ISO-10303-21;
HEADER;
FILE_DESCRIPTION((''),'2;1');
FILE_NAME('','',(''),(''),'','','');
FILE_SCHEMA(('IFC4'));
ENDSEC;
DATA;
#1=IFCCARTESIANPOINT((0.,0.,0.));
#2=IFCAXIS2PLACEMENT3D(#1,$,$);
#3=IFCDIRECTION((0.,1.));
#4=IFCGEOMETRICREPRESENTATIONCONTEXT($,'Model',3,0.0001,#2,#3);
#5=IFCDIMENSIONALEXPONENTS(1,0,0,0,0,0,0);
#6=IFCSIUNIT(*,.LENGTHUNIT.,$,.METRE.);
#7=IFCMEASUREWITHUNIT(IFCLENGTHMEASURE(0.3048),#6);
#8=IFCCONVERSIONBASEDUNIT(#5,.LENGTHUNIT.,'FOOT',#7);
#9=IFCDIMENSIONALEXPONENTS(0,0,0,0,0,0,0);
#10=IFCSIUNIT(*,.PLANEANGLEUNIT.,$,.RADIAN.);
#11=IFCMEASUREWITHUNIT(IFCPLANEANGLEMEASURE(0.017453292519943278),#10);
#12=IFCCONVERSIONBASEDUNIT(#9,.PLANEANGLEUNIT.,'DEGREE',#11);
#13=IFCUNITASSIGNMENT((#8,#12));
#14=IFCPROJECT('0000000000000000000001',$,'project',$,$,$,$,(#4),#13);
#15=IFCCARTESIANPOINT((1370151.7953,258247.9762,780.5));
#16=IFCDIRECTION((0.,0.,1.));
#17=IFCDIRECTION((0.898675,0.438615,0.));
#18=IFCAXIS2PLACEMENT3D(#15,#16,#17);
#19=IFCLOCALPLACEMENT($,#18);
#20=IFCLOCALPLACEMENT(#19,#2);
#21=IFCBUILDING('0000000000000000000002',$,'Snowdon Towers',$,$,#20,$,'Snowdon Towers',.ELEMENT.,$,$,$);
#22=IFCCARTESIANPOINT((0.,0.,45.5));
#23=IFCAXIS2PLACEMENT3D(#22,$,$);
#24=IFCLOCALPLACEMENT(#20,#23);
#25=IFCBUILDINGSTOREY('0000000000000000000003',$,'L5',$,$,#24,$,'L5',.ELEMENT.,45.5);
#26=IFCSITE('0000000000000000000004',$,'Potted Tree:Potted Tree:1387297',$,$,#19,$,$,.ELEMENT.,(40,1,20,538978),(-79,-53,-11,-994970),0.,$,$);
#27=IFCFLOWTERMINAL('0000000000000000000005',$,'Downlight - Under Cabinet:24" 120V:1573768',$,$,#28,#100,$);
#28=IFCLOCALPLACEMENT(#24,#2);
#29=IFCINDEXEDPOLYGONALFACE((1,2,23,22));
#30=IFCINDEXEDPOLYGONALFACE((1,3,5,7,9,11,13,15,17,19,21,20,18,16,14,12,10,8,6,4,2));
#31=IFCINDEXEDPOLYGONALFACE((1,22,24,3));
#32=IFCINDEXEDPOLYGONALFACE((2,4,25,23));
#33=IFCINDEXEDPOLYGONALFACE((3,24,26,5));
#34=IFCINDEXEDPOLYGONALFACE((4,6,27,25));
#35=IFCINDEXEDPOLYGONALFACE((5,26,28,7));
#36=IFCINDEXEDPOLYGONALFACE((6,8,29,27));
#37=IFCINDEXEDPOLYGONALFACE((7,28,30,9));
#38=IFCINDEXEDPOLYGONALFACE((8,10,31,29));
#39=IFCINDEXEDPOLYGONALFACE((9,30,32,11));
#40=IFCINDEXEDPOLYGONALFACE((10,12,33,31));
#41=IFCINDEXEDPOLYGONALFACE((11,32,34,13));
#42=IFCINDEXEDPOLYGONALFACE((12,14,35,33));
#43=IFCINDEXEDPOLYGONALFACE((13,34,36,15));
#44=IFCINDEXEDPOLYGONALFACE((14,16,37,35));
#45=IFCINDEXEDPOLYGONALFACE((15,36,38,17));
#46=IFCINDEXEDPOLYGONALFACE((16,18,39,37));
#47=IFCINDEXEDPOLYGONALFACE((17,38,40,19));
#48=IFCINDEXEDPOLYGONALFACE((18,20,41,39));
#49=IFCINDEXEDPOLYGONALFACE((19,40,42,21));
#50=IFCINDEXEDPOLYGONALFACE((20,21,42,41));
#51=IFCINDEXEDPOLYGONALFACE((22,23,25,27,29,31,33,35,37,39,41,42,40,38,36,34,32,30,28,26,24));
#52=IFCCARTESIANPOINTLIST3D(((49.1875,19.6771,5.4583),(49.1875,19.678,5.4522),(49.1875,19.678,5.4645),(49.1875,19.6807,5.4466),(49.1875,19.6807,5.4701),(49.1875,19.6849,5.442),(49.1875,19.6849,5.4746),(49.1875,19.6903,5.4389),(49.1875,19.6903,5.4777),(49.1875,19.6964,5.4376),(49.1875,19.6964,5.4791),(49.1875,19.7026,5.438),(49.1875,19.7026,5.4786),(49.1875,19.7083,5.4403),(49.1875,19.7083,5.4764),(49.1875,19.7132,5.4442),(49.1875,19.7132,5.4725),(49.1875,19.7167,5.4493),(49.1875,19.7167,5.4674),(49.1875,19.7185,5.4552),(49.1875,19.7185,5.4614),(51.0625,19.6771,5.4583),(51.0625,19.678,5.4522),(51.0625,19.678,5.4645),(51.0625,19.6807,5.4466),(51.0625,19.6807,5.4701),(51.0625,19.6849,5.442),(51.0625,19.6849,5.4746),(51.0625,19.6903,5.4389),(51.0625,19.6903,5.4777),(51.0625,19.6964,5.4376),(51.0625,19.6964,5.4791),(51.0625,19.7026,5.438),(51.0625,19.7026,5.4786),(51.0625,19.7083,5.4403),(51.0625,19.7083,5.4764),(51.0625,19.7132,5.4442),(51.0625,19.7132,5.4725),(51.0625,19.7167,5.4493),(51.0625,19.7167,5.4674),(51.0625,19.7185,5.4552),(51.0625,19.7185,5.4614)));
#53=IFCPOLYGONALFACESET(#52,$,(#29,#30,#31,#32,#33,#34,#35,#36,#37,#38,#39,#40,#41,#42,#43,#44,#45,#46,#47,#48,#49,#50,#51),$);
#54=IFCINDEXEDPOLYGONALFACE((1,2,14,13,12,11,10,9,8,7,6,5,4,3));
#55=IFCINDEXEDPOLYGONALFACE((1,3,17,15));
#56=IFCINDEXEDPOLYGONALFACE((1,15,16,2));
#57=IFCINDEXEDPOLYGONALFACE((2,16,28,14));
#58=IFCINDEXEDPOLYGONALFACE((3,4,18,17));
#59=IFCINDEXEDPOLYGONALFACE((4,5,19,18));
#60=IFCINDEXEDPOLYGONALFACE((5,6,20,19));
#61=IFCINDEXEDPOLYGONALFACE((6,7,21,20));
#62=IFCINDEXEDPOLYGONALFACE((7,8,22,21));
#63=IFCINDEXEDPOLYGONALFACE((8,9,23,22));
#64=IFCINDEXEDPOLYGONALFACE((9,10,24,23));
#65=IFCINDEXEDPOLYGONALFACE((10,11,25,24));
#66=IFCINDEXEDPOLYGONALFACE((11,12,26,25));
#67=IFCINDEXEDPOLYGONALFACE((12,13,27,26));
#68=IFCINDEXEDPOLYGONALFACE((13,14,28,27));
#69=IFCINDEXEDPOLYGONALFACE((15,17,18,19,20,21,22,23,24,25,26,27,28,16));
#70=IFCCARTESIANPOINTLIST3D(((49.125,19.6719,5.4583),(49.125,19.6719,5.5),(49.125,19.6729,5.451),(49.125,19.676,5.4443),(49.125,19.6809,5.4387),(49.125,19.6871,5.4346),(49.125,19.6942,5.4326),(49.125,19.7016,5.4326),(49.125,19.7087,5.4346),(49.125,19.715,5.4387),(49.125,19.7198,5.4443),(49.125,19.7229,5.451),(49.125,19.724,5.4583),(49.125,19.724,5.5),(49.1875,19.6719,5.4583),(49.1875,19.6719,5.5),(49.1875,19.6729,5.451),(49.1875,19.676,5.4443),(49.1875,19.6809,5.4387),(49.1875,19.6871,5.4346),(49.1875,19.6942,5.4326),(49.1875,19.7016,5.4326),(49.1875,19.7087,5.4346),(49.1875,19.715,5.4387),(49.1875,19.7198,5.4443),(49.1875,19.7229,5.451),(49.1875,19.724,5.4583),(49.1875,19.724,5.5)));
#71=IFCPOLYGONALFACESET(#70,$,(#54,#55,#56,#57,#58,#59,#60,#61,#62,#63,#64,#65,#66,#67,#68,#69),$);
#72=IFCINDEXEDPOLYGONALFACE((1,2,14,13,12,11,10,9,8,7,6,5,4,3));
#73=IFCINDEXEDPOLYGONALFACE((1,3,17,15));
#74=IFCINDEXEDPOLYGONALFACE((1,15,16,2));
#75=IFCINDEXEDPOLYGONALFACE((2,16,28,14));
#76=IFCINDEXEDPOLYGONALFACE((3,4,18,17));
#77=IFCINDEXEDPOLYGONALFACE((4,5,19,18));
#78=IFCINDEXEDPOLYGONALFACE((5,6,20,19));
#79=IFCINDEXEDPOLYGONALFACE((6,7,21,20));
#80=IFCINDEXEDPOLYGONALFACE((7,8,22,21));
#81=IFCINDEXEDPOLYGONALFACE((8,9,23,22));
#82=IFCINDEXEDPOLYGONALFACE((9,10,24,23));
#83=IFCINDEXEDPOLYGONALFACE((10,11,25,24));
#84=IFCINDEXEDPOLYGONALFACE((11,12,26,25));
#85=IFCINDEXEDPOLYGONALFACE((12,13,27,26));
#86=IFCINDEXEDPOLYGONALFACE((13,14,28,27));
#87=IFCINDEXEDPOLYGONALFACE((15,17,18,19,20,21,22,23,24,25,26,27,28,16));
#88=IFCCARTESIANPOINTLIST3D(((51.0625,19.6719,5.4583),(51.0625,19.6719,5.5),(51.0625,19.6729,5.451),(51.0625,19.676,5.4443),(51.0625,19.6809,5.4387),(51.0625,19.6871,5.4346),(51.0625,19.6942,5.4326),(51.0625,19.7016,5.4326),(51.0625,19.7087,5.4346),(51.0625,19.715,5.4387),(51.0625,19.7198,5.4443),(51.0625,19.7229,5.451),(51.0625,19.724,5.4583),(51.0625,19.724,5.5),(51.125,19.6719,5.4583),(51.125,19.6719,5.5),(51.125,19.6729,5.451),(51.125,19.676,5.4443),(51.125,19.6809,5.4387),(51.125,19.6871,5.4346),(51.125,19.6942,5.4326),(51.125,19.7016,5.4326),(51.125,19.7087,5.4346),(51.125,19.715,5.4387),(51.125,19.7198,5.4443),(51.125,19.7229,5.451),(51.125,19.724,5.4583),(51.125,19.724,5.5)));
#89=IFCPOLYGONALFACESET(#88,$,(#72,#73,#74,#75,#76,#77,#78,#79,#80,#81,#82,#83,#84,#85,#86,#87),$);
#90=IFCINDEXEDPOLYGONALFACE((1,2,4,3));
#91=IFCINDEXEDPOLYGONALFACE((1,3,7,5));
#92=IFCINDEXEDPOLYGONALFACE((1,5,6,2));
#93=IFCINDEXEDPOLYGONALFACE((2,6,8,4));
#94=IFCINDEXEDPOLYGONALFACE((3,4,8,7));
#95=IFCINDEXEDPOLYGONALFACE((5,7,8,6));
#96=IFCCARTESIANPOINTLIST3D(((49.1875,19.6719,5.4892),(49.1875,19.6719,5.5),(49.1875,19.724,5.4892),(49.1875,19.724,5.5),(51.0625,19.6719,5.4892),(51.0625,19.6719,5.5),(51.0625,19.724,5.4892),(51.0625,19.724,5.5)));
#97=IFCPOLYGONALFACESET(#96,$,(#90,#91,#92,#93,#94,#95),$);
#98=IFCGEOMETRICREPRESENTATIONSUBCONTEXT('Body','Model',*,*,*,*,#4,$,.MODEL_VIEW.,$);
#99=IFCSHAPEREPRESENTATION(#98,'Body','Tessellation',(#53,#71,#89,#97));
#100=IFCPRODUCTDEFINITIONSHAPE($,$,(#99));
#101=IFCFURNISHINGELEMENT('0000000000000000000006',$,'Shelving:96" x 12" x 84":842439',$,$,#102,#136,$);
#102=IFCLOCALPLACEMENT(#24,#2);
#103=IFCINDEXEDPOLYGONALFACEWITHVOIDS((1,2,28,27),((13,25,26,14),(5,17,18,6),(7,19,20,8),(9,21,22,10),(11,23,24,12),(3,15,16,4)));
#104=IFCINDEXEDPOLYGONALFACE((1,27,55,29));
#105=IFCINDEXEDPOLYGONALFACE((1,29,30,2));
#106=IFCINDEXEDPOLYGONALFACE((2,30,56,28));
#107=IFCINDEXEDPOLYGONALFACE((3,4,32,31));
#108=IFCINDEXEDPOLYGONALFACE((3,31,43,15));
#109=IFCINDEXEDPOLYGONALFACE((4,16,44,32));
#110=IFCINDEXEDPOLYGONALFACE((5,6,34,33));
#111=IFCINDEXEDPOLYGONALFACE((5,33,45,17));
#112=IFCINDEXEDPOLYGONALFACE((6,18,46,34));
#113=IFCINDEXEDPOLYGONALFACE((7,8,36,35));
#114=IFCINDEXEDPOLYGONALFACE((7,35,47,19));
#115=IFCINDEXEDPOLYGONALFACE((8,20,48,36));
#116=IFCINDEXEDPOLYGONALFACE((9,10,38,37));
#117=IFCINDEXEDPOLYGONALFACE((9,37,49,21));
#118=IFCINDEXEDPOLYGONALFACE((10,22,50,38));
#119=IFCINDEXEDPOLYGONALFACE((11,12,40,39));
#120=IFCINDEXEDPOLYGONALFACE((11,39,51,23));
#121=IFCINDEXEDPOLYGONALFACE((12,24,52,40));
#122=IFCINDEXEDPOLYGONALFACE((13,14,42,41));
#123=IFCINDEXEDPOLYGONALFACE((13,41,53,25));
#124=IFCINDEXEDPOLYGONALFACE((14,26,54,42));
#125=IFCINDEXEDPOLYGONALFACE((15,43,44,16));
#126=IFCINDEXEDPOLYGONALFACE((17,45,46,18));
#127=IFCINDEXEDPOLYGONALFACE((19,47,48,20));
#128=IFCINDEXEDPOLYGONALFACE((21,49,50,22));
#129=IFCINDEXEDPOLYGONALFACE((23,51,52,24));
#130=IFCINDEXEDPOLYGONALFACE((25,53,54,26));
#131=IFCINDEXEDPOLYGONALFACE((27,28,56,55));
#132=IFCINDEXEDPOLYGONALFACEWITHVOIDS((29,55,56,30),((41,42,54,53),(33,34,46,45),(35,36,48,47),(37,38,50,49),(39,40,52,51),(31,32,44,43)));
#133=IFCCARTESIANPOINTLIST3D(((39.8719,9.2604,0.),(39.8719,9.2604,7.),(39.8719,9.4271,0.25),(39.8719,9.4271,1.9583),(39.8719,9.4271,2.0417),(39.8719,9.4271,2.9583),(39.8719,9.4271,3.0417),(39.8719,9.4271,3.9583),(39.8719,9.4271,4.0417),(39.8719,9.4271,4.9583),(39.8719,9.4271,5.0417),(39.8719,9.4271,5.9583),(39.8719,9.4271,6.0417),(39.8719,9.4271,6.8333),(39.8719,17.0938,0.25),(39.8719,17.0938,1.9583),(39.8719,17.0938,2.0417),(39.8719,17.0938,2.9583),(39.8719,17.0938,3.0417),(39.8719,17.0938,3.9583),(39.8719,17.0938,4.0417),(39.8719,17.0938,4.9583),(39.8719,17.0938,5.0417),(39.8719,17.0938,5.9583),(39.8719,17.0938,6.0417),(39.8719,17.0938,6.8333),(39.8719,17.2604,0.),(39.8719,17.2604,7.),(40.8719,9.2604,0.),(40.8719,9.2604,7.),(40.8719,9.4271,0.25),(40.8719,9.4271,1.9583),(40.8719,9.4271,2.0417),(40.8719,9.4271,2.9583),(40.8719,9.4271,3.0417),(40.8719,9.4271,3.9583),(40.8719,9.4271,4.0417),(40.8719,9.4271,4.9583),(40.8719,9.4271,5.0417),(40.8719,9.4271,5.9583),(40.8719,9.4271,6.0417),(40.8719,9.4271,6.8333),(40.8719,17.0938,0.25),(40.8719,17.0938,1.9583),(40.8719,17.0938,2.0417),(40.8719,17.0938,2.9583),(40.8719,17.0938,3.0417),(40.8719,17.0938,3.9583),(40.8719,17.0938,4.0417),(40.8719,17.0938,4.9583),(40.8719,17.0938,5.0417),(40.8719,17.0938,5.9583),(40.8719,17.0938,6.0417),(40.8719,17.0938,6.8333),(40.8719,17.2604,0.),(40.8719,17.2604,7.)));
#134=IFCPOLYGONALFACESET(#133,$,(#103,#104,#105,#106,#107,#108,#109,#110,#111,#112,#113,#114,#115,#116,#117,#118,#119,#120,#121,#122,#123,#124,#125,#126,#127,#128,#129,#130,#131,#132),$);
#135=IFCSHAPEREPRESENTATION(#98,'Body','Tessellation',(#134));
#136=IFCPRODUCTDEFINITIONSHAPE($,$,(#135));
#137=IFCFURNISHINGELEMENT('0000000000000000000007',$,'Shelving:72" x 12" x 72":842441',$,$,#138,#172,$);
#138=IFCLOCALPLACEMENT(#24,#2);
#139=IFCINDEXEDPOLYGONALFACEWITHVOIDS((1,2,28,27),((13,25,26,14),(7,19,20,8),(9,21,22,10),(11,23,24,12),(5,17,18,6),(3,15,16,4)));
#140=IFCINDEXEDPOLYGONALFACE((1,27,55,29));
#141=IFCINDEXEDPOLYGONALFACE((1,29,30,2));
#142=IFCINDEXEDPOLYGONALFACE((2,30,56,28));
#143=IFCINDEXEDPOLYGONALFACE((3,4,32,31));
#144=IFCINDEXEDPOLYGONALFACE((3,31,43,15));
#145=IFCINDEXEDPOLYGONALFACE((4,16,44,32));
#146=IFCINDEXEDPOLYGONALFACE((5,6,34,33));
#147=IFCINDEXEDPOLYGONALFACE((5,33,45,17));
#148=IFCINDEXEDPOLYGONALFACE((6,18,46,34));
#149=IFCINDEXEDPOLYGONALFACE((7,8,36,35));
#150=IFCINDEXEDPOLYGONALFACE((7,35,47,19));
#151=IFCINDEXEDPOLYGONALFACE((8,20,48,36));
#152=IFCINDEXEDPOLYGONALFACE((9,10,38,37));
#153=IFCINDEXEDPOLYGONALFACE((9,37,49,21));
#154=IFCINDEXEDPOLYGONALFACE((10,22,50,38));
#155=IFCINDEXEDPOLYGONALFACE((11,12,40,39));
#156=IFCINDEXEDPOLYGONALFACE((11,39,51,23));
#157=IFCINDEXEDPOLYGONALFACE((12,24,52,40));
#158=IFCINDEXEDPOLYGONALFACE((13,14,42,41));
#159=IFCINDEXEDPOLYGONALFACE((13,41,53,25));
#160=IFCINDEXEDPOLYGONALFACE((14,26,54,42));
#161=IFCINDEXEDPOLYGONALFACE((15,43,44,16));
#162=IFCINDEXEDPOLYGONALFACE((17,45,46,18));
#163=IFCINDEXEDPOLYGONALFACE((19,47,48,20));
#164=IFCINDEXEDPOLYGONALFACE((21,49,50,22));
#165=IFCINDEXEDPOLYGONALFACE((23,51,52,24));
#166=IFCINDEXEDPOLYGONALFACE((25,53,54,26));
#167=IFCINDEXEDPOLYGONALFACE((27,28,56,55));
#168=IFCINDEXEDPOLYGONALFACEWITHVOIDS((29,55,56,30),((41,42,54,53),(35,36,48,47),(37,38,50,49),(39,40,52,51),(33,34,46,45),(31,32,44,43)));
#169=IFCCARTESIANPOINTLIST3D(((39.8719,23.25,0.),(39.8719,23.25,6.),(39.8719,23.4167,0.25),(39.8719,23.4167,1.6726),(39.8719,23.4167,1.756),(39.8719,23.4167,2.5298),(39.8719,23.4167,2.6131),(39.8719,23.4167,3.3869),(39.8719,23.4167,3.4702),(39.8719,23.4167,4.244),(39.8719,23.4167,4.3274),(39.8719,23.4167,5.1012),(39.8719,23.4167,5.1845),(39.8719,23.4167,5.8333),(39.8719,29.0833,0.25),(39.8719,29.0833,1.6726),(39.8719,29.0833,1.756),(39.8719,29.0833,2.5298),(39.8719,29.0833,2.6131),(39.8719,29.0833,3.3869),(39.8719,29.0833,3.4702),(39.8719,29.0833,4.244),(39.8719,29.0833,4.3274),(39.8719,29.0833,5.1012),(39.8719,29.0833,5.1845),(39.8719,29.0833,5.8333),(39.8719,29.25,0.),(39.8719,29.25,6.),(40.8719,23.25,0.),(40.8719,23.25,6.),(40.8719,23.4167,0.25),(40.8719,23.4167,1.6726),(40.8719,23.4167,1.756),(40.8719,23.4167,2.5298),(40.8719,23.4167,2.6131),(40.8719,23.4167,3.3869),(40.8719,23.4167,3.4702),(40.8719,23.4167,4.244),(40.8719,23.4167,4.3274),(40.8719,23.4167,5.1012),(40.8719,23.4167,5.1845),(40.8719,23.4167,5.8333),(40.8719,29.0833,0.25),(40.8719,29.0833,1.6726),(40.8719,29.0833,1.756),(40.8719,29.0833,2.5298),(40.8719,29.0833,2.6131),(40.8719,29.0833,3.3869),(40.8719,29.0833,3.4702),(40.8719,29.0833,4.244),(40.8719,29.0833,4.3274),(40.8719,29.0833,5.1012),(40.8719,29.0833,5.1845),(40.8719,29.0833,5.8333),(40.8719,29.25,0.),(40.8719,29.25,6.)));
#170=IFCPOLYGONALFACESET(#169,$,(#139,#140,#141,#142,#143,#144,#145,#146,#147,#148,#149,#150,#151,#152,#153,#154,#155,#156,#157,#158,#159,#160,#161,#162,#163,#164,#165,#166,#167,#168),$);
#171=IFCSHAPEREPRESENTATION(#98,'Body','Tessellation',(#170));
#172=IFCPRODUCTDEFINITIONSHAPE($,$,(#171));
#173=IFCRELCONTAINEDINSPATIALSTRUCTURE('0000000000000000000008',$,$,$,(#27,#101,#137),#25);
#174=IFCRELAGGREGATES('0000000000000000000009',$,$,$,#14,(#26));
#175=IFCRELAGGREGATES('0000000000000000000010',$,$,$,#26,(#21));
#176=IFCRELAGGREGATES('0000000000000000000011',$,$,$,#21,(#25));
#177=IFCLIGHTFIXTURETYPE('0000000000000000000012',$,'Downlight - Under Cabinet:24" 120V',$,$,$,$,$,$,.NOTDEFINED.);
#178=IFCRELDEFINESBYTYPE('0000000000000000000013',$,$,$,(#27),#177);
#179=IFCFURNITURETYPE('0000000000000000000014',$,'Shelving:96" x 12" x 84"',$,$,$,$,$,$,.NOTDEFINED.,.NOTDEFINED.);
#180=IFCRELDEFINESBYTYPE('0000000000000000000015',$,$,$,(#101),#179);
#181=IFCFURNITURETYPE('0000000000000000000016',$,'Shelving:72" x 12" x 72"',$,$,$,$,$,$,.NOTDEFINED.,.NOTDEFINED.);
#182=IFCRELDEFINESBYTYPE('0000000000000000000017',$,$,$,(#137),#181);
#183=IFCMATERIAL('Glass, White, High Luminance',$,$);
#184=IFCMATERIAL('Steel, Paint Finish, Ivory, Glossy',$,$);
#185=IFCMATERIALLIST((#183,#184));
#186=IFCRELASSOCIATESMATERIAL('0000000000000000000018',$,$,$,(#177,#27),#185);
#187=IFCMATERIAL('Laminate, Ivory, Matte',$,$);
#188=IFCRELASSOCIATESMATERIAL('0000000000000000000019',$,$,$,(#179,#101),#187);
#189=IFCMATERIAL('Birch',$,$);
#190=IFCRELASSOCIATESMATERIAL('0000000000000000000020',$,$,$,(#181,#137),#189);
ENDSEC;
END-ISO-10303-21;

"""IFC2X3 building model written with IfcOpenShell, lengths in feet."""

from ifc_helpers import new_model, entity, si_unit, converted_unit, direction, frame, frame_2d, origin, origin_2d_with_axis, place, context, subcontext, project, spatial, polyline, circle_curve, parameter, trimmed, segment, composite_curve, rectangle, circle, outline, extrude, source, transform, mapped, material, material_list, type_object, type_shapes, element, save


model = new_model("IFC2X3")

# Units and contexts
model_context = context("Model", 3, precision=0.0001, world=origin(), true_north=direction((0.0, 1.0)))
body_context = subcontext(model_context, "Body", "Model", "MODEL_VIEW")
ifc_project = project(units=[converted_unit("LENGTHUNIT", "FOOT", entity("IfcLengthMeasure", 0.3048), si_unit("LENGTHUNIT", "METRE"), dimensions=[1, 0, 0, 0, 0, 0, 0]), converted_unit("PLANEANGLEUNIT", "DEGREE", entity("IfcPlaneAngleMeasure", 0.017453292519943278), si_unit("PLANEANGLEUNIT", "RADIAN"), dimensions=[0, 0, 0, 0, 0, 0, 0])], contexts=[model_context])

# Site, building, storey
site_placement = place(None, frame((1370151.7953, 258247.9762, 780.5), z_axis=(0.0, 0.0, 1.0), x_axis=(0.898675, 0.438615, 0.0)))
site = spatial("IfcSite", under=ifc_project, at=site_placement, Name="Potted Tree:Potted Tree:1387297", CompositionType="ELEMENT", RefLatitude=(40, 1, 20, 538978), RefLongitude=(-79, -53, -11, -994970), RefElevation=0.0)
building_placement = place(site_placement, origin())
building = spatial("IfcBuilding", under=site, at=building_placement, Name="Snowdon Towers", LongName="Snowdon Towers", CompositionType="ELEMENT")
storey_placement = place(building_placement, frame((0.0, 0.0, 45.5)))
storey = spatial("IfcBuildingStorey", under=building, at=storey_placement, Name="L5", LongName="L5", CompositionType="ELEMENT", Elevation=45.5)

# Flow terminal
ifc_material_1 = material(Name="Glass, White, High Luminance")
ifc_material_2 = material(Name="Steel, Paint Finish, Ivory, Glossy")
ifc_material_list_1 = material_list([ifc_material_1, ifc_material_2])
light_fixture_type_1 = type_object("IfcLightFixtureType", Name="Downlight - Under Cabinet:24\" 120V", PredefinedType="NOTDEFINED", material=ifc_material_list_1)
shared_shape_1 = source(origin(), body_context, "Body", "SweptSolid", [
    extrude(circle(Radius=0.0208, at=origin_2d_with_axis()), frame((-0.9375, 0.0, 4.4583), z_axis=(1.0, 0.0, 0.0), x_axis=(0.0, 1.0, 0.0)), (0.0, 0.0, 1.0), 1.875),
    extrude(outline(composite_curve([segment(polyline([(-0.0208, -0.026), (0.0208, -0.026)]), True, "CONTINUOUS"), segment(trimmed(circle_curve(frame_2d((0.0208, 0.0), x_axis=(0.0, 1.0)), 0.026), [parameter(180.0)], [parameter(0.0)], True, "PARAMETER"), True, "CONTINUOUS"), segment(polyline([(0.0208, 0.026), (-0.0208, 0.026)]), True, "CONTINUOUS"), segment(polyline([(-0.0208, 0.026), (-0.0208, -0.026)]), True, "CONTINUOUS")], self_intersect=False)), frame((0.9375, 0.0, 4.4792), z_axis=(1.0, 0.0, 0.0), x_axis=(0.0, 0.0, -1.0)), (0.0, 0.0, 1.0), 0.0625),
    extrude(outline(composite_curve([segment(polyline([(-0.026, -0.0208), (0.026, -0.0208)]), True, "CONTINUOUS"), segment(polyline([(0.026, -0.0208), (0.026, 0.0208)]), True, "CONTINUOUS"), segment(trimmed(circle_curve(frame_2d((0.0, 0.0208), x_axis=(0.0, -1.0)), 0.026), [parameter(90.0)], [parameter(270.0)], True, "PARAMETER"), True, "CONTINUOUS"), segment(polyline([(-0.026, 0.0208), (-0.026, -0.0208)]), True, "CONTINUOUS")], self_intersect=False)), frame((-1.0, 0.0, 4.4792), z_axis=(1.0, 0.0, 0.0), x_axis=(0.0, -1.0, 0.0)), (0.0, 0.0, 1.0), 0.0625),
    extrude(rectangle(XDim=1.875, YDim=0.0521, at=origin_2d_with_axis()), frame((0.0, 0.0, 4.4892), z_axis=(0.0, 0.0, 1.0), x_axis=(-1.0, 0.0, 0.0)), (0.0, 0.0, 1.0), 0.0108),
])
type_shapes(light_fixture_type_1, [shared_shape_1])
flow_terminal_1_placement = place(storey_placement, frame((50.125, 19.6979, 1.0), z_axis=(0.0, 0.0, 1.0), x_axis=(-1.0, 0.0, 0.0)))
element("IfcFlowTerminal", 1, at=flow_terminal_1_placement, inside=storey, type_object=light_fixture_type_1, material=ifc_material_list_1, Name="Downlight - Under Cabinet:24\" 120V:1573768", context=body_context, shape_type="MappedRepresentation", body=[
    mapped(shared_shape_1, transform((0.0, 0.0, 0.0), scale=1.0)),
])

# Furnishing elements
ifc_material_3 = material(Name="Laminate, Ivory, Matte")
furniture_type_1 = type_object("IfcFurnitureType", Name="Shelving:96\" x 12\" x 84\"", AssemblyPlace="NOTDEFINED", material=ifc_material_3)
shared_shape_2 = source(origin(), body_context, "Body", "SweptSolid", [
    extrude(outline(polyline([(-4.0, -3.5), (4.0, -3.5), (4.0, 3.5), (-4.0, 3.5), (-4.0, -3.5)]), holes=[polyline([(-3.8333, 3.3333), (3.8333, 3.3333), (3.8333, 2.5417), (-3.8333, 2.5417), (-3.8333, 3.3333)]), polyline([(-3.8333, -3.25), (-3.8333, -1.5417), (3.8333, -1.5417), (3.8333, -3.25), (-3.8333, -3.25)]), polyline([(3.8333, 0.5417), (-3.8333, 0.5417), (-3.8333, 1.4583), (3.8333, 1.4583), (3.8333, 0.5417)]), polyline([(-3.8333, 2.4583), (3.8333, 2.4583), (3.8333, 1.5417), (-3.8333, 1.5417), (-3.8333, 2.4583)]), polyline([(-3.8333, 0.4583), (3.8333, 0.4583), (3.8333, -0.4583), (-3.8333, -0.4583), (-3.8333, 0.4583)]), polyline([(-3.8333, -0.5417), (3.8333, -0.5417), (3.8333, -1.4583), (-3.8333, -1.4583), (-3.8333, -0.5417)])]), frame((0.0, -1.5, 3.5), z_axis=(0.0, 1.0, 0.0), x_axis=(-1.0, 0.0, 0.0)), (0.0, 0.0, 1.0), 1.0),
])
type_shapes(furniture_type_1, [shared_shape_2])
furnishing_1_placement = place(storey_placement, frame((39.3719, 13.2604, 0.0), z_axis=(0.0, 0.0, 1.0), x_axis=(0.0, 1.0, 0.0)))
element("IfcFurnishingElement", 2, at=furnishing_1_placement, inside=storey, type_object=furniture_type_1, material=ifc_material_3, Name="Shelving:96\" x 12\" x 84\":842439", context=body_context, shape_type="MappedRepresentation", body=[
    mapped(shared_shape_2, transform((0.0, 0.0, 0.0), scale=1.0)),
])
ifc_material_4 = material(Name="Birch")
furniture_type_2 = type_object("IfcFurnitureType", Name="Shelving:72\" x 12\" x 72\"", AssemblyPlace="NOTDEFINED", material=ifc_material_4)
shared_shape_3 = source(origin(), body_context, "Body", "SweptSolid", [
    extrude(outline(polyline([(-3.0, -3.0), (3.0, -3.0), (3.0, 3.0), (-3.0, 3.0), (-3.0, -3.0)]), holes=[polyline([(-2.8333, 2.8333), (2.8333, 2.8333), (2.8333, 2.1845), (-2.8333, 2.1845), (-2.8333, 2.8333)]), polyline([(-2.8333, -2.75), (-2.8333, -1.3274), (2.8333, -1.3274), (2.8333, -2.75), (-2.8333, -2.75)]), polyline([(2.8333, 0.4702), (-2.8333, 0.4702), (-2.8333, 1.244), (2.8333, 1.244), (2.8333, 0.4702)]), polyline([(-2.8333, 2.1012), (2.8333, 2.1012), (2.8333, 1.3274), (-2.8333, 1.3274), (-2.8333, 2.1012)]), polyline([(-2.8333, 0.3869), (2.8333, 0.3869), (2.8333, -0.3869), (-2.8333, -0.3869), (-2.8333, 0.3869)]), polyline([(-2.8333, -0.4702), (2.8333, -0.4702), (2.8333, -1.244), (-2.8333, -1.244), (-2.8333, -0.4702)])]), frame((0.0, -1.5, 3.0), z_axis=(0.0, 1.0, 0.0), x_axis=(-1.0, 0.0, 0.0)), (0.0, 0.0, 1.0), 1.0),
])
type_shapes(furniture_type_2, [shared_shape_3])
furnishing_2_placement = place(storey_placement, frame((39.3719, 26.25, 0.0), z_axis=(0.0, 0.0, 1.0), x_axis=(0.0, 1.0, 0.0)))
element("IfcFurnishingElement", 3, at=furnishing_2_placement, inside=storey, type_object=furniture_type_2, material=ifc_material_4, Name="Shelving:72\" x 12\" x 72\":842441", context=body_context, shape_type="MappedRepresentation", body=[
    mapped(shared_shape_3, transform((0.0, 0.0, 0.0), scale=1.0)),
])

save(model, "model.ifc")
